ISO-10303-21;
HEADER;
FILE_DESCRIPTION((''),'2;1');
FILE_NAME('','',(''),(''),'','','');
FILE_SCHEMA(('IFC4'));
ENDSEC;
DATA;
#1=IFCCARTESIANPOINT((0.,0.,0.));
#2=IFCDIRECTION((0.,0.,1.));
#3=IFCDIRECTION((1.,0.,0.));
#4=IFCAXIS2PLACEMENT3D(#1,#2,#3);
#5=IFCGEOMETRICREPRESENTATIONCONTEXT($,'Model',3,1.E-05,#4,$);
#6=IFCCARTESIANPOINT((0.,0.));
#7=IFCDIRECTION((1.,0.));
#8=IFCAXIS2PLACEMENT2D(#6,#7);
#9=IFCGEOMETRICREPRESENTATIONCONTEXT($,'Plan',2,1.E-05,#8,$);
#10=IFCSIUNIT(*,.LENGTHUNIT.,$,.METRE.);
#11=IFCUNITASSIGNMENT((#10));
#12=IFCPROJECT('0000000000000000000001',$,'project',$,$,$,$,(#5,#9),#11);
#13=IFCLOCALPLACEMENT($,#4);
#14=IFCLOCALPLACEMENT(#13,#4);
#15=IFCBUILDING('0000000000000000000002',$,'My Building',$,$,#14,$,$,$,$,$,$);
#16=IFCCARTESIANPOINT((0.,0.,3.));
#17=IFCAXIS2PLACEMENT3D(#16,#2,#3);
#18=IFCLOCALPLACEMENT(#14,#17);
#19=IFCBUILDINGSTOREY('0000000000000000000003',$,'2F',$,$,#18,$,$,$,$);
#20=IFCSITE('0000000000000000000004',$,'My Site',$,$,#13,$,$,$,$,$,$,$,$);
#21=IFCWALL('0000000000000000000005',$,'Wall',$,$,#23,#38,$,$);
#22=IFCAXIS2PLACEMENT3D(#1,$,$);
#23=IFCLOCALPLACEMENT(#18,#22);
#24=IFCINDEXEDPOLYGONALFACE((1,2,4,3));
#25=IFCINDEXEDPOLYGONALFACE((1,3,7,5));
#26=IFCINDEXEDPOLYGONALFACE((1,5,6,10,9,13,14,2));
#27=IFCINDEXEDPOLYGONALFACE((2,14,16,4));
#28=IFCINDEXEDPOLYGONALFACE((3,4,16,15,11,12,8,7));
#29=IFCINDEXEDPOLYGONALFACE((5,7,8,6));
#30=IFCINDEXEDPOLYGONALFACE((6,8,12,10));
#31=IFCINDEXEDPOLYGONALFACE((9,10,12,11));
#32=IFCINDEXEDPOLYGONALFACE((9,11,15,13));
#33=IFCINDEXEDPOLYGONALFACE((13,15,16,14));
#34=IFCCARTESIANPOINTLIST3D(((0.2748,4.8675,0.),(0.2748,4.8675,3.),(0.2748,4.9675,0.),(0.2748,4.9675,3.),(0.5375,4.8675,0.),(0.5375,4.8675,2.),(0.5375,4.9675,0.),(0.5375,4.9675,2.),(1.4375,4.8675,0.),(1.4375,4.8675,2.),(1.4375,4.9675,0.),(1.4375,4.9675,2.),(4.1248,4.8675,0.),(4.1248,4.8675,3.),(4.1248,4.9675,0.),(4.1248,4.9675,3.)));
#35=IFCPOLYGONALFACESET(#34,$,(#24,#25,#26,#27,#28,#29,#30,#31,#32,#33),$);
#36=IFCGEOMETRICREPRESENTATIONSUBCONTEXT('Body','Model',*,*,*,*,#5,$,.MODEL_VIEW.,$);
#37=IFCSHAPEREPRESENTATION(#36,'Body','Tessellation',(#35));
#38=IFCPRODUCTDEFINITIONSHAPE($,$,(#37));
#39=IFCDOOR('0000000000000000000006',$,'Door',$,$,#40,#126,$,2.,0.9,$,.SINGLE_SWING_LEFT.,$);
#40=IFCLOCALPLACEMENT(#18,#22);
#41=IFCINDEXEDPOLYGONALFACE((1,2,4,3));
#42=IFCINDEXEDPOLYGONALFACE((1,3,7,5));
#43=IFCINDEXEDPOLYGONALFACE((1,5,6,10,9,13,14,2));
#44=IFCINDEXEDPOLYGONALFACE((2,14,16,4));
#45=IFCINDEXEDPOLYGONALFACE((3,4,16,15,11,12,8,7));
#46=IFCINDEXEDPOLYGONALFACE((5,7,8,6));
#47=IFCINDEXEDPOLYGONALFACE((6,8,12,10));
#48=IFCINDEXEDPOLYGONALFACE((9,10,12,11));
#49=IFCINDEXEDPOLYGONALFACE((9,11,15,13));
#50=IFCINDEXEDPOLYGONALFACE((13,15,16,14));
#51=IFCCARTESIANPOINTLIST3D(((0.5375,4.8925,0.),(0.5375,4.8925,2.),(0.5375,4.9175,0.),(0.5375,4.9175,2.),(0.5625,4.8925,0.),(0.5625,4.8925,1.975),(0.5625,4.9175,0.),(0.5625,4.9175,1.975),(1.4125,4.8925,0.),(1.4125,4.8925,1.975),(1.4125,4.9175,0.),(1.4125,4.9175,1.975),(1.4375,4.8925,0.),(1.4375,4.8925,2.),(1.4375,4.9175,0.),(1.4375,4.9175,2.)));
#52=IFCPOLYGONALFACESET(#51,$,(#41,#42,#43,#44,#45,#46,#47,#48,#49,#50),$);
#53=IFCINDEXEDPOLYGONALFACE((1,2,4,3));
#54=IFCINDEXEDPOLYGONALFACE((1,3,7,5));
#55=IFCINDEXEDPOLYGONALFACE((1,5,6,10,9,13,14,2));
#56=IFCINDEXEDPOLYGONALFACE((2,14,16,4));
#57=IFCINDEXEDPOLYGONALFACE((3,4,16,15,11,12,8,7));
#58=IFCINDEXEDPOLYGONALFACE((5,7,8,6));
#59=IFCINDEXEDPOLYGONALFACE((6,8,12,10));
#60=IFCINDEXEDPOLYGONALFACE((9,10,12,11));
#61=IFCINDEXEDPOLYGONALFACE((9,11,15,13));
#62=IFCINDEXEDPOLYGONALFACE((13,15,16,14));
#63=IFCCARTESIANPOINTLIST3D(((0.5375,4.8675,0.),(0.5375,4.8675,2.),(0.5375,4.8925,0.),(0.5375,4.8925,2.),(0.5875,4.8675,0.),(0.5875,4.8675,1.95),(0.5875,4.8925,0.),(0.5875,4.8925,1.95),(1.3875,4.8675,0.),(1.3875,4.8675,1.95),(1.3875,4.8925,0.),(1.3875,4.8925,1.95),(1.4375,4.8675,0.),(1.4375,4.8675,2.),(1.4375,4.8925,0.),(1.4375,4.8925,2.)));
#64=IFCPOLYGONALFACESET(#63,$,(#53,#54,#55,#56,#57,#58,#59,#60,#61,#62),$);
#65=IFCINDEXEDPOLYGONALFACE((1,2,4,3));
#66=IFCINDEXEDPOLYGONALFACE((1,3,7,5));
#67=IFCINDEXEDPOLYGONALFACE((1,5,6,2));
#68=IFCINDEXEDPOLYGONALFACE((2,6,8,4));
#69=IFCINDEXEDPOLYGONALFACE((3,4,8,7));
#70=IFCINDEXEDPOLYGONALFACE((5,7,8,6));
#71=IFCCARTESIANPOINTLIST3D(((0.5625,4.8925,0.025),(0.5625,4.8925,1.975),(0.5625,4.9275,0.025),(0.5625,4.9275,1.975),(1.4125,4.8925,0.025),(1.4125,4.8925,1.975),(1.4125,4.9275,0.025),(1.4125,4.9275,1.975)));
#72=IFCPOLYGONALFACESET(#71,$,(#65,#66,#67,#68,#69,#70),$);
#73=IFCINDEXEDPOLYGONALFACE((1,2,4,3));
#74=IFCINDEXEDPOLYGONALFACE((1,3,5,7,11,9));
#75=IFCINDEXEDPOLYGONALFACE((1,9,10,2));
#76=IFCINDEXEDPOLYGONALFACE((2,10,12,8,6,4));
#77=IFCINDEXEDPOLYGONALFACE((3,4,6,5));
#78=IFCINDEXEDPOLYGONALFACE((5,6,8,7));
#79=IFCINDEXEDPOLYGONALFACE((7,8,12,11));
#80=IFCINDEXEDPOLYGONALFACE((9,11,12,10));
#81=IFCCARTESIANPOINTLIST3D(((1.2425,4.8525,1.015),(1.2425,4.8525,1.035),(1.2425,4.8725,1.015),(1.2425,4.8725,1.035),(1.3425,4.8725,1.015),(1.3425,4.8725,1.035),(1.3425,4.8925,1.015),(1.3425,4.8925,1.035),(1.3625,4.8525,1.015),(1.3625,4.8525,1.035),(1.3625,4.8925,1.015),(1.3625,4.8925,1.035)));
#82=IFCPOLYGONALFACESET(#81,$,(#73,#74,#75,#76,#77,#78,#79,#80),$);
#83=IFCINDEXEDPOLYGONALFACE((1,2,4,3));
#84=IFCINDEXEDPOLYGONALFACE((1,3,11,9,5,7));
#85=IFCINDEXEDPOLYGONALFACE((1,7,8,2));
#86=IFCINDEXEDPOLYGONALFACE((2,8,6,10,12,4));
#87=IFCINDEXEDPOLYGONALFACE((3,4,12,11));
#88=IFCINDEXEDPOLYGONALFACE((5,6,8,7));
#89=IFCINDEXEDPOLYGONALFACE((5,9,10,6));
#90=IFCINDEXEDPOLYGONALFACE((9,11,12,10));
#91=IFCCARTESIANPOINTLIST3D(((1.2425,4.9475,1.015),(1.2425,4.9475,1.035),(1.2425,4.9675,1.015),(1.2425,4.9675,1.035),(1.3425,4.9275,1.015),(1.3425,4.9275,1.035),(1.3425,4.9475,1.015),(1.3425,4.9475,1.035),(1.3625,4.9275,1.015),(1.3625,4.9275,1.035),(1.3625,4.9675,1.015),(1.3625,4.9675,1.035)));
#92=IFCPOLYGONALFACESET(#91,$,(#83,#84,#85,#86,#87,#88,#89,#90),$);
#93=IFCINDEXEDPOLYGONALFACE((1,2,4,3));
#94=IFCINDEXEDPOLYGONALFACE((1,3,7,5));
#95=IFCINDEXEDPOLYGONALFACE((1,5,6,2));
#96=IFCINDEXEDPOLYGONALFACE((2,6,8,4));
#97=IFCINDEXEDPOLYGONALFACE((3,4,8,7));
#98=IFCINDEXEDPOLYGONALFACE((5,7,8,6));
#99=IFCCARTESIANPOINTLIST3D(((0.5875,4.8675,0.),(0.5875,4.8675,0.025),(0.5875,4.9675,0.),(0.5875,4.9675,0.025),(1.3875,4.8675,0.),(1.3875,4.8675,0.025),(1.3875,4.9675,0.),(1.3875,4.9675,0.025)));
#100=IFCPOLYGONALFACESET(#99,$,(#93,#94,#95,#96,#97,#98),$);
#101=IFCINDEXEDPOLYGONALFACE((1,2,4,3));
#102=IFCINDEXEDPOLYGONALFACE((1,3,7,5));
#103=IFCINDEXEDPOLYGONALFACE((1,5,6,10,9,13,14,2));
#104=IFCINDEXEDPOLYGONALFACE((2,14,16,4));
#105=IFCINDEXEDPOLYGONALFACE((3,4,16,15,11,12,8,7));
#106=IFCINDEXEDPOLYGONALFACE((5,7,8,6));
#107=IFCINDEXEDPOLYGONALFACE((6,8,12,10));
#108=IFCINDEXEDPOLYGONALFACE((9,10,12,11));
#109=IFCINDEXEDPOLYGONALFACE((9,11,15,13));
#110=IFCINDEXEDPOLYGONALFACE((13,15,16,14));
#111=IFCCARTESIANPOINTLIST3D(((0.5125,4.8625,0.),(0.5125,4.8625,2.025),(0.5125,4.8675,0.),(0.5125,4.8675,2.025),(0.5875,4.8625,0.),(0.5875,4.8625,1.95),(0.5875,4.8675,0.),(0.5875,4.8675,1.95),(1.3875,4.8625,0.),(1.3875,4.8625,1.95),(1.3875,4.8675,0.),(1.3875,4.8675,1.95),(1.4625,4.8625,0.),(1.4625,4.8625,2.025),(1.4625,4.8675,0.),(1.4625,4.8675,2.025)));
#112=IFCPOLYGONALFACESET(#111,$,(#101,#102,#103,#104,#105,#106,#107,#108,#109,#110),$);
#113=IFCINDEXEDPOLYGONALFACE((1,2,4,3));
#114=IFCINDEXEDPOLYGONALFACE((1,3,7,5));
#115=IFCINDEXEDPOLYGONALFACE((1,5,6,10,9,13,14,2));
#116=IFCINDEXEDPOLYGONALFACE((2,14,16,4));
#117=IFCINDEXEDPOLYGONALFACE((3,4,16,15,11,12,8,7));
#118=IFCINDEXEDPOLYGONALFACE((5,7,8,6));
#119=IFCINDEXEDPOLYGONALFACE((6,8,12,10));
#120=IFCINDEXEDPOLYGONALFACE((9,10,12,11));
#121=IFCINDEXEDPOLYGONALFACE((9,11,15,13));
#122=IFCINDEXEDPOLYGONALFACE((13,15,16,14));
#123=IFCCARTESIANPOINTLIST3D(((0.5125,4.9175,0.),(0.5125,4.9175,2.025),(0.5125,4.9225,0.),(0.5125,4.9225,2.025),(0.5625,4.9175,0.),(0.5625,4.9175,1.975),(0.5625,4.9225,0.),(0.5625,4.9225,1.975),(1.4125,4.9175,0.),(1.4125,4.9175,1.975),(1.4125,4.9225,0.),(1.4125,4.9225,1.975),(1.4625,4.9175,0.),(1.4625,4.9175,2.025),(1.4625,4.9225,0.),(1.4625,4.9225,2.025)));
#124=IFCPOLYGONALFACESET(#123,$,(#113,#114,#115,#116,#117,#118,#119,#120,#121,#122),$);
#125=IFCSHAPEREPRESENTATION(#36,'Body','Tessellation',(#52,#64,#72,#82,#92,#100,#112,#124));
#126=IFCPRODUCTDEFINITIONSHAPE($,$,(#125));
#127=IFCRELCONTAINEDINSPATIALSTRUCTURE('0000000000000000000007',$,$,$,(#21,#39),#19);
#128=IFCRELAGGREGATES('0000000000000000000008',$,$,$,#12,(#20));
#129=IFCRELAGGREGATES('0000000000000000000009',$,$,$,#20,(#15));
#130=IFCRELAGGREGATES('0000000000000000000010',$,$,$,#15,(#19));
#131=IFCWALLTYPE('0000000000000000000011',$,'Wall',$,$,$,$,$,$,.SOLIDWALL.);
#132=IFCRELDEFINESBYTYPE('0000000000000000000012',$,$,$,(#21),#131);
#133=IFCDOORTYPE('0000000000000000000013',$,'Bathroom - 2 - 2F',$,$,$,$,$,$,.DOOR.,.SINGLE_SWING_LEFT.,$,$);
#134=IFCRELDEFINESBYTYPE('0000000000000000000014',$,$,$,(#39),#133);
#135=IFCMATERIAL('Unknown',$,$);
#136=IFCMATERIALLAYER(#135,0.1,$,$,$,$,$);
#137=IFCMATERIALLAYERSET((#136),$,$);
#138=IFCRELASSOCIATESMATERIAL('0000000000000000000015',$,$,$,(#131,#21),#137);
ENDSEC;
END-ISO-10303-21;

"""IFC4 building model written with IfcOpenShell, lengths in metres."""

from ifc_helpers import new_model, entity, si_unit, frame, origin_with_axes, origin_2d_with_axis, place, context, subcontext, project, spatial, line, indexed_curve, outline, extrude, shape, source, transform, mapped, material, layer, layer_set, layer_usage, type_object, type_shapes, element, fill, save


model = new_model("IFC4")

# Units and contexts
model_context = context("Model", 3, precision=1e-05, world=origin_with_axes())
plan_context = context("Plan", 2, precision=1e-05, world=origin_2d_with_axis())
body_context_1 = subcontext(model_context, "Body", "Model", "MODEL_VIEW")
body_context_2 = subcontext(plan_context, "Body", "Plan", "PLAN_VIEW")
ifc_project = project(units=[si_unit("LENGTHUNIT", "METRE")], contexts=[model_context, plan_context])

# Site, building, storey
site_placement = place(None, origin_with_axes())
site = spatial("IfcSite", under=ifc_project, at=site_placement, Name="My Site")
building_placement = place(site_placement, origin_with_axes())
building = spatial("IfcBuilding", under=site, at=building_placement, Name="My Building")
storey_placement = place(building_placement, frame((0.0, 0.0, 3.0), z_axis=(0.0, 0.0, 1.0), x_axis=(1.0, 0.0, 0.0)))
storey = spatial("IfcBuildingStorey", under=building, at=storey_placement, Name="2F")

# Shared definitions
ifc_material = material(Name="Unknown")

# Shared definitions
ifc_layer = layer(ifc_material, 0.1)
ifc_layer_set = layer_set([ifc_layer])
wall_type = type_object("IfcWallType", Name="Wall", PredefinedType="SOLIDWALL", material=ifc_layer_set)

# Wall, opening, door
ifc_layer_usage_1 = layer_usage(ifc_layer_set, "AXIS2", "POSITIVE", 0.0)
wall_1_placement = place(storey_placement, frame((4.1248, 4.9675, 0.0), z_axis=(0.0, 0.0, 1.0), x_axis=(-1.0, 0.0, 0.0)))
wall_1 = element("IfcWall", 1, at=wall_1_placement, inside=storey, type_object=wall_type, material=ifc_layer_usage_1, Name="Wall", context=body_context_1, shape_type="SweptSolid", body=[
    extrude(outline(indexed_curve([(0.0, 0.0), (0.0, 0.1), (3.85, 0.1), (3.85, 0.0)], segments=[line(1, 2, 3, 4, 1)])), origin_with_axes(), (0.0, 0.0, 1.0), 3.0),
])
shared_shape_1 = source(origin_with_axes(), body_context_1, "Body", "SweptSolid", [
    extrude(outline(indexed_curve([(0.0, 0.0), (0.9, 0.0), (0.9, 2.0), (0.0, 2.0)], segments=[line(1, 2, 3, 4, 1)])), frame((0.0, -0.6, 0.0), z_axis=(0.0, -1.0, 0.0), x_axis=(1.0, 0.0, 0.0)), (0.0, 0.0, -1.0), 1.2),
])
opening_1_placement = place(wall_1_placement, frame((3.5873, 0.1, 0.0), z_axis=(0.0, 0.0, 1.0), x_axis=(-1.0, 0.0, 0.0)))
opening_1 = element("IfcOpeningElement", 2, at=opening_1_placement, cuts=wall_1, PredefinedType="OPENING", context=body_context_1, shape_type="MappedRepresentation", body=[
    mapped(shared_shape_1, transform((0.0, 0.0, 0.0), x_axis=(1.0, 0.0, 0.0), y_axis=(0.0, 1.0, 0.0), z_axis=(0.0, 0.0, 1.0), scale=1.0)),
])
door_type = type_object("IfcDoorType", Name="Bathroom - 2 - 2F", OperationType="SINGLE_SWING_LEFT", PredefinedType="DOOR")
shared_shape_2 = source(origin_with_axes(), body_context_1, "Body", "SweptSolid", [
    extrude(outline(indexed_curve([(0.0, 0.0), (0.0, 2.0), (0.9, 2.0), (0.9, 0.0), (0.875, 0.0), (0.875, 1.975), (0.025, 1.975), (0.025, 0.0)], segments=[line(1, 2, 3, 4, 5, 6, 7, 8, 1)])), frame((0.0, 0.025, 0.0), z_axis=(0.0, -1.0, 0.0), x_axis=(1.0, 0.0, 0.0)), (0.0, 0.0, -1.0), 0.025),
    extrude(outline(indexed_curve([(0.0, 0.0), (0.0, 2.0), (0.9, 2.0), (0.9, 0.0), (0.85, 0.0), (0.85, 1.95), (0.05, 1.95), (0.05, 0.0)], segments=[line(1, 2, 3, 4, 5, 6, 7, 8, 1)])), frame((0.0, 0.0, 0.0), z_axis=(0.0, -1.0, 0.0), x_axis=(1.0, 0.0, 0.0)), (0.0, 0.0, -1.0), 0.025),
    extrude(outline(indexed_curve([(0.0, 0.0), (0.85, 0.0), (0.85, 0.035), (0.0, 0.035)], segments=[line(1, 2, 3, 4, 1)])), frame((0.025, 0.025, 0.025), z_axis=(0.0, 0.0, 1.0), x_axis=(1.0, 0.0, 0.0)), (0.0, 0.0, 1.0), 1.95),
    extrude(outline(indexed_curve([(0.0, 0.0), (0.0, -0.04), (-0.12, -0.04), (-0.12, -0.02), (-0.02, -0.02), (-0.02, 0.0)], segments=[line(1, 2, 3, 4, 5, 6, 1)])), frame((0.825, 0.025, 1.015), z_axis=(0.0, 0.0, 1.0), x_axis=(1.0, 0.0, 0.0)), (0.0, 0.0, 1.0), 0.02),
    extrude(outline(indexed_curve([(0.0, 0.0), (0.0, 0.04), (-0.12, 0.04), (-0.12, 0.02), (-0.02, 0.02), (-0.02, 0.0)], segments=[line(1, 2, 3, 4, 5, 6, 1)])), frame((0.825, 0.06, 1.015), z_axis=(0.0, 0.0, 1.0), x_axis=(1.0, 0.0, 0.0)), (0.0, 0.0, 1.0), 0.02),
    extrude(outline(indexed_curve([(0.0, 0.0), (0.8, 0.0), (0.8, 0.1), (0.0, 0.1)], segments=[line(1, 2, 3, 4, 1)])), frame((0.05, 0.0, 0.0), z_axis=(0.0, 0.0, 1.0), x_axis=(1.0, 0.0, 0.0)), (0.0, 0.0, 1.0), 0.025),
    extrude(outline(indexed_curve([(0.0, 0.0), (0.0, 2.025), (0.95, 2.025), (0.95, 0.0), (0.875, 0.0), (0.875, 1.95), (0.075, 1.95), (0.075, 0.0)], segments=[line(1, 2, 3, 4, 5, 6, 7, 8, 1)])), frame((-0.025, -0.005, 0.0), z_axis=(0.0, -1.0, 0.0), x_axis=(1.0, 0.0, 0.0)), (0.0, 0.0, -1.0), 0.005),
    extrude(outline(indexed_curve([(0.0, 0.0), (0.0, 2.025), (0.95, 2.025), (0.95, 0.0), (0.9, 0.0), (0.9, 1.975), (0.05, 1.975), (0.05, 0.0)], segments=[line(1, 2, 3, 4, 5, 6, 7, 8, 1)])), frame((-0.025, 0.05, 0.0), z_axis=(0.0, -1.0, 0.0), x_axis=(1.0, 0.0, 0.0)), (0.0, 0.0, -1.0), 0.005),
])
shared_shape_3 = source(origin_with_axes(), body_context_2, "Body", "Curve2D", [
    entity("IfcIndexedPolyCurve", entity("IfcCartesianPointList2D", [[0.0, 0.0], [0.0, 0.05], [0.025, 0.05], [0.025, 0.025], [0.05, 0.025], [0.05, 0.0]]), [entity("IfcLineIndex", [1, 2, 3, 4, 5, 6, 1])]),
    entity("IfcIndexedPolyCurve", entity("IfcCartesianPointList2D", [[0.9, 0.0], [0.9, 0.05], [0.875, 0.05], [0.875, 0.025], [0.85, 0.025], [0.85, 0.0]]), [entity("IfcLineIndex", [1, 2, 3, 4, 5, 6, 1])]),
    entity("IfcTrimmedCurve", entity("IfcEllipse", entity("IfcAxis2Placement2D", entity("IfcCartesianPoint", [0.06, 0.05]), entity("IfcDirection", [1.0, 0.0])), 0.815, 0.85), [entity("IfcCartesianPoint", [0.875, 0.05])], [entity("IfcCartesianPoint", [0.06, 0.9])], True, "CARTESIAN"),
    entity("IfcIndexedPolyCurve", entity("IfcCartesianPointList2D", [[0.025, 0.05], [0.06, 0.05], [0.06, 0.9], [0.025, 0.9]]), [entity("IfcLineIndex", [1, 2, 3, 4, 1])]),
])
type_shapes(door_type, [shared_shape_2, shared_shape_3])
door_placement = place(opening_1_placement, frame((0.0, 0.0, 0.0), z_axis=(0.0, 0.0, 1.0), x_axis=(1.0, 0.0, 0.0)))
door = element("IfcDoor", 3, at=door_placement, inside=storey, type_object=door_type, Name="Door", OperationType="SINGLE_SWING_LEFT", OverallHeight=2.0, OverallWidth=0.9, shapes=[
    shape(body_context_1, "Body", "MappedRepresentation", [mapped(shared_shape_2, transform((0.0, 0.0, 0.0), x_axis=(1.0, 0.0, 0.0), y_axis=(0.0, 1.0, 0.0), z_axis=(0.0, 0.0, 1.0), scale=1.0))]),
    shape(body_context_2, "Body", "MappedRepresentation", [mapped(shared_shape_3, transform((0.0, 0.0, 0.0), x_axis=(1.0, 0.0, 0.0), y_axis=(0.0, 1.0, 0.0), z_axis=(0.0, 0.0, 1.0), scale=1.0))]),
])
fill(opening_1, door)

save(model, "model.ifc")
